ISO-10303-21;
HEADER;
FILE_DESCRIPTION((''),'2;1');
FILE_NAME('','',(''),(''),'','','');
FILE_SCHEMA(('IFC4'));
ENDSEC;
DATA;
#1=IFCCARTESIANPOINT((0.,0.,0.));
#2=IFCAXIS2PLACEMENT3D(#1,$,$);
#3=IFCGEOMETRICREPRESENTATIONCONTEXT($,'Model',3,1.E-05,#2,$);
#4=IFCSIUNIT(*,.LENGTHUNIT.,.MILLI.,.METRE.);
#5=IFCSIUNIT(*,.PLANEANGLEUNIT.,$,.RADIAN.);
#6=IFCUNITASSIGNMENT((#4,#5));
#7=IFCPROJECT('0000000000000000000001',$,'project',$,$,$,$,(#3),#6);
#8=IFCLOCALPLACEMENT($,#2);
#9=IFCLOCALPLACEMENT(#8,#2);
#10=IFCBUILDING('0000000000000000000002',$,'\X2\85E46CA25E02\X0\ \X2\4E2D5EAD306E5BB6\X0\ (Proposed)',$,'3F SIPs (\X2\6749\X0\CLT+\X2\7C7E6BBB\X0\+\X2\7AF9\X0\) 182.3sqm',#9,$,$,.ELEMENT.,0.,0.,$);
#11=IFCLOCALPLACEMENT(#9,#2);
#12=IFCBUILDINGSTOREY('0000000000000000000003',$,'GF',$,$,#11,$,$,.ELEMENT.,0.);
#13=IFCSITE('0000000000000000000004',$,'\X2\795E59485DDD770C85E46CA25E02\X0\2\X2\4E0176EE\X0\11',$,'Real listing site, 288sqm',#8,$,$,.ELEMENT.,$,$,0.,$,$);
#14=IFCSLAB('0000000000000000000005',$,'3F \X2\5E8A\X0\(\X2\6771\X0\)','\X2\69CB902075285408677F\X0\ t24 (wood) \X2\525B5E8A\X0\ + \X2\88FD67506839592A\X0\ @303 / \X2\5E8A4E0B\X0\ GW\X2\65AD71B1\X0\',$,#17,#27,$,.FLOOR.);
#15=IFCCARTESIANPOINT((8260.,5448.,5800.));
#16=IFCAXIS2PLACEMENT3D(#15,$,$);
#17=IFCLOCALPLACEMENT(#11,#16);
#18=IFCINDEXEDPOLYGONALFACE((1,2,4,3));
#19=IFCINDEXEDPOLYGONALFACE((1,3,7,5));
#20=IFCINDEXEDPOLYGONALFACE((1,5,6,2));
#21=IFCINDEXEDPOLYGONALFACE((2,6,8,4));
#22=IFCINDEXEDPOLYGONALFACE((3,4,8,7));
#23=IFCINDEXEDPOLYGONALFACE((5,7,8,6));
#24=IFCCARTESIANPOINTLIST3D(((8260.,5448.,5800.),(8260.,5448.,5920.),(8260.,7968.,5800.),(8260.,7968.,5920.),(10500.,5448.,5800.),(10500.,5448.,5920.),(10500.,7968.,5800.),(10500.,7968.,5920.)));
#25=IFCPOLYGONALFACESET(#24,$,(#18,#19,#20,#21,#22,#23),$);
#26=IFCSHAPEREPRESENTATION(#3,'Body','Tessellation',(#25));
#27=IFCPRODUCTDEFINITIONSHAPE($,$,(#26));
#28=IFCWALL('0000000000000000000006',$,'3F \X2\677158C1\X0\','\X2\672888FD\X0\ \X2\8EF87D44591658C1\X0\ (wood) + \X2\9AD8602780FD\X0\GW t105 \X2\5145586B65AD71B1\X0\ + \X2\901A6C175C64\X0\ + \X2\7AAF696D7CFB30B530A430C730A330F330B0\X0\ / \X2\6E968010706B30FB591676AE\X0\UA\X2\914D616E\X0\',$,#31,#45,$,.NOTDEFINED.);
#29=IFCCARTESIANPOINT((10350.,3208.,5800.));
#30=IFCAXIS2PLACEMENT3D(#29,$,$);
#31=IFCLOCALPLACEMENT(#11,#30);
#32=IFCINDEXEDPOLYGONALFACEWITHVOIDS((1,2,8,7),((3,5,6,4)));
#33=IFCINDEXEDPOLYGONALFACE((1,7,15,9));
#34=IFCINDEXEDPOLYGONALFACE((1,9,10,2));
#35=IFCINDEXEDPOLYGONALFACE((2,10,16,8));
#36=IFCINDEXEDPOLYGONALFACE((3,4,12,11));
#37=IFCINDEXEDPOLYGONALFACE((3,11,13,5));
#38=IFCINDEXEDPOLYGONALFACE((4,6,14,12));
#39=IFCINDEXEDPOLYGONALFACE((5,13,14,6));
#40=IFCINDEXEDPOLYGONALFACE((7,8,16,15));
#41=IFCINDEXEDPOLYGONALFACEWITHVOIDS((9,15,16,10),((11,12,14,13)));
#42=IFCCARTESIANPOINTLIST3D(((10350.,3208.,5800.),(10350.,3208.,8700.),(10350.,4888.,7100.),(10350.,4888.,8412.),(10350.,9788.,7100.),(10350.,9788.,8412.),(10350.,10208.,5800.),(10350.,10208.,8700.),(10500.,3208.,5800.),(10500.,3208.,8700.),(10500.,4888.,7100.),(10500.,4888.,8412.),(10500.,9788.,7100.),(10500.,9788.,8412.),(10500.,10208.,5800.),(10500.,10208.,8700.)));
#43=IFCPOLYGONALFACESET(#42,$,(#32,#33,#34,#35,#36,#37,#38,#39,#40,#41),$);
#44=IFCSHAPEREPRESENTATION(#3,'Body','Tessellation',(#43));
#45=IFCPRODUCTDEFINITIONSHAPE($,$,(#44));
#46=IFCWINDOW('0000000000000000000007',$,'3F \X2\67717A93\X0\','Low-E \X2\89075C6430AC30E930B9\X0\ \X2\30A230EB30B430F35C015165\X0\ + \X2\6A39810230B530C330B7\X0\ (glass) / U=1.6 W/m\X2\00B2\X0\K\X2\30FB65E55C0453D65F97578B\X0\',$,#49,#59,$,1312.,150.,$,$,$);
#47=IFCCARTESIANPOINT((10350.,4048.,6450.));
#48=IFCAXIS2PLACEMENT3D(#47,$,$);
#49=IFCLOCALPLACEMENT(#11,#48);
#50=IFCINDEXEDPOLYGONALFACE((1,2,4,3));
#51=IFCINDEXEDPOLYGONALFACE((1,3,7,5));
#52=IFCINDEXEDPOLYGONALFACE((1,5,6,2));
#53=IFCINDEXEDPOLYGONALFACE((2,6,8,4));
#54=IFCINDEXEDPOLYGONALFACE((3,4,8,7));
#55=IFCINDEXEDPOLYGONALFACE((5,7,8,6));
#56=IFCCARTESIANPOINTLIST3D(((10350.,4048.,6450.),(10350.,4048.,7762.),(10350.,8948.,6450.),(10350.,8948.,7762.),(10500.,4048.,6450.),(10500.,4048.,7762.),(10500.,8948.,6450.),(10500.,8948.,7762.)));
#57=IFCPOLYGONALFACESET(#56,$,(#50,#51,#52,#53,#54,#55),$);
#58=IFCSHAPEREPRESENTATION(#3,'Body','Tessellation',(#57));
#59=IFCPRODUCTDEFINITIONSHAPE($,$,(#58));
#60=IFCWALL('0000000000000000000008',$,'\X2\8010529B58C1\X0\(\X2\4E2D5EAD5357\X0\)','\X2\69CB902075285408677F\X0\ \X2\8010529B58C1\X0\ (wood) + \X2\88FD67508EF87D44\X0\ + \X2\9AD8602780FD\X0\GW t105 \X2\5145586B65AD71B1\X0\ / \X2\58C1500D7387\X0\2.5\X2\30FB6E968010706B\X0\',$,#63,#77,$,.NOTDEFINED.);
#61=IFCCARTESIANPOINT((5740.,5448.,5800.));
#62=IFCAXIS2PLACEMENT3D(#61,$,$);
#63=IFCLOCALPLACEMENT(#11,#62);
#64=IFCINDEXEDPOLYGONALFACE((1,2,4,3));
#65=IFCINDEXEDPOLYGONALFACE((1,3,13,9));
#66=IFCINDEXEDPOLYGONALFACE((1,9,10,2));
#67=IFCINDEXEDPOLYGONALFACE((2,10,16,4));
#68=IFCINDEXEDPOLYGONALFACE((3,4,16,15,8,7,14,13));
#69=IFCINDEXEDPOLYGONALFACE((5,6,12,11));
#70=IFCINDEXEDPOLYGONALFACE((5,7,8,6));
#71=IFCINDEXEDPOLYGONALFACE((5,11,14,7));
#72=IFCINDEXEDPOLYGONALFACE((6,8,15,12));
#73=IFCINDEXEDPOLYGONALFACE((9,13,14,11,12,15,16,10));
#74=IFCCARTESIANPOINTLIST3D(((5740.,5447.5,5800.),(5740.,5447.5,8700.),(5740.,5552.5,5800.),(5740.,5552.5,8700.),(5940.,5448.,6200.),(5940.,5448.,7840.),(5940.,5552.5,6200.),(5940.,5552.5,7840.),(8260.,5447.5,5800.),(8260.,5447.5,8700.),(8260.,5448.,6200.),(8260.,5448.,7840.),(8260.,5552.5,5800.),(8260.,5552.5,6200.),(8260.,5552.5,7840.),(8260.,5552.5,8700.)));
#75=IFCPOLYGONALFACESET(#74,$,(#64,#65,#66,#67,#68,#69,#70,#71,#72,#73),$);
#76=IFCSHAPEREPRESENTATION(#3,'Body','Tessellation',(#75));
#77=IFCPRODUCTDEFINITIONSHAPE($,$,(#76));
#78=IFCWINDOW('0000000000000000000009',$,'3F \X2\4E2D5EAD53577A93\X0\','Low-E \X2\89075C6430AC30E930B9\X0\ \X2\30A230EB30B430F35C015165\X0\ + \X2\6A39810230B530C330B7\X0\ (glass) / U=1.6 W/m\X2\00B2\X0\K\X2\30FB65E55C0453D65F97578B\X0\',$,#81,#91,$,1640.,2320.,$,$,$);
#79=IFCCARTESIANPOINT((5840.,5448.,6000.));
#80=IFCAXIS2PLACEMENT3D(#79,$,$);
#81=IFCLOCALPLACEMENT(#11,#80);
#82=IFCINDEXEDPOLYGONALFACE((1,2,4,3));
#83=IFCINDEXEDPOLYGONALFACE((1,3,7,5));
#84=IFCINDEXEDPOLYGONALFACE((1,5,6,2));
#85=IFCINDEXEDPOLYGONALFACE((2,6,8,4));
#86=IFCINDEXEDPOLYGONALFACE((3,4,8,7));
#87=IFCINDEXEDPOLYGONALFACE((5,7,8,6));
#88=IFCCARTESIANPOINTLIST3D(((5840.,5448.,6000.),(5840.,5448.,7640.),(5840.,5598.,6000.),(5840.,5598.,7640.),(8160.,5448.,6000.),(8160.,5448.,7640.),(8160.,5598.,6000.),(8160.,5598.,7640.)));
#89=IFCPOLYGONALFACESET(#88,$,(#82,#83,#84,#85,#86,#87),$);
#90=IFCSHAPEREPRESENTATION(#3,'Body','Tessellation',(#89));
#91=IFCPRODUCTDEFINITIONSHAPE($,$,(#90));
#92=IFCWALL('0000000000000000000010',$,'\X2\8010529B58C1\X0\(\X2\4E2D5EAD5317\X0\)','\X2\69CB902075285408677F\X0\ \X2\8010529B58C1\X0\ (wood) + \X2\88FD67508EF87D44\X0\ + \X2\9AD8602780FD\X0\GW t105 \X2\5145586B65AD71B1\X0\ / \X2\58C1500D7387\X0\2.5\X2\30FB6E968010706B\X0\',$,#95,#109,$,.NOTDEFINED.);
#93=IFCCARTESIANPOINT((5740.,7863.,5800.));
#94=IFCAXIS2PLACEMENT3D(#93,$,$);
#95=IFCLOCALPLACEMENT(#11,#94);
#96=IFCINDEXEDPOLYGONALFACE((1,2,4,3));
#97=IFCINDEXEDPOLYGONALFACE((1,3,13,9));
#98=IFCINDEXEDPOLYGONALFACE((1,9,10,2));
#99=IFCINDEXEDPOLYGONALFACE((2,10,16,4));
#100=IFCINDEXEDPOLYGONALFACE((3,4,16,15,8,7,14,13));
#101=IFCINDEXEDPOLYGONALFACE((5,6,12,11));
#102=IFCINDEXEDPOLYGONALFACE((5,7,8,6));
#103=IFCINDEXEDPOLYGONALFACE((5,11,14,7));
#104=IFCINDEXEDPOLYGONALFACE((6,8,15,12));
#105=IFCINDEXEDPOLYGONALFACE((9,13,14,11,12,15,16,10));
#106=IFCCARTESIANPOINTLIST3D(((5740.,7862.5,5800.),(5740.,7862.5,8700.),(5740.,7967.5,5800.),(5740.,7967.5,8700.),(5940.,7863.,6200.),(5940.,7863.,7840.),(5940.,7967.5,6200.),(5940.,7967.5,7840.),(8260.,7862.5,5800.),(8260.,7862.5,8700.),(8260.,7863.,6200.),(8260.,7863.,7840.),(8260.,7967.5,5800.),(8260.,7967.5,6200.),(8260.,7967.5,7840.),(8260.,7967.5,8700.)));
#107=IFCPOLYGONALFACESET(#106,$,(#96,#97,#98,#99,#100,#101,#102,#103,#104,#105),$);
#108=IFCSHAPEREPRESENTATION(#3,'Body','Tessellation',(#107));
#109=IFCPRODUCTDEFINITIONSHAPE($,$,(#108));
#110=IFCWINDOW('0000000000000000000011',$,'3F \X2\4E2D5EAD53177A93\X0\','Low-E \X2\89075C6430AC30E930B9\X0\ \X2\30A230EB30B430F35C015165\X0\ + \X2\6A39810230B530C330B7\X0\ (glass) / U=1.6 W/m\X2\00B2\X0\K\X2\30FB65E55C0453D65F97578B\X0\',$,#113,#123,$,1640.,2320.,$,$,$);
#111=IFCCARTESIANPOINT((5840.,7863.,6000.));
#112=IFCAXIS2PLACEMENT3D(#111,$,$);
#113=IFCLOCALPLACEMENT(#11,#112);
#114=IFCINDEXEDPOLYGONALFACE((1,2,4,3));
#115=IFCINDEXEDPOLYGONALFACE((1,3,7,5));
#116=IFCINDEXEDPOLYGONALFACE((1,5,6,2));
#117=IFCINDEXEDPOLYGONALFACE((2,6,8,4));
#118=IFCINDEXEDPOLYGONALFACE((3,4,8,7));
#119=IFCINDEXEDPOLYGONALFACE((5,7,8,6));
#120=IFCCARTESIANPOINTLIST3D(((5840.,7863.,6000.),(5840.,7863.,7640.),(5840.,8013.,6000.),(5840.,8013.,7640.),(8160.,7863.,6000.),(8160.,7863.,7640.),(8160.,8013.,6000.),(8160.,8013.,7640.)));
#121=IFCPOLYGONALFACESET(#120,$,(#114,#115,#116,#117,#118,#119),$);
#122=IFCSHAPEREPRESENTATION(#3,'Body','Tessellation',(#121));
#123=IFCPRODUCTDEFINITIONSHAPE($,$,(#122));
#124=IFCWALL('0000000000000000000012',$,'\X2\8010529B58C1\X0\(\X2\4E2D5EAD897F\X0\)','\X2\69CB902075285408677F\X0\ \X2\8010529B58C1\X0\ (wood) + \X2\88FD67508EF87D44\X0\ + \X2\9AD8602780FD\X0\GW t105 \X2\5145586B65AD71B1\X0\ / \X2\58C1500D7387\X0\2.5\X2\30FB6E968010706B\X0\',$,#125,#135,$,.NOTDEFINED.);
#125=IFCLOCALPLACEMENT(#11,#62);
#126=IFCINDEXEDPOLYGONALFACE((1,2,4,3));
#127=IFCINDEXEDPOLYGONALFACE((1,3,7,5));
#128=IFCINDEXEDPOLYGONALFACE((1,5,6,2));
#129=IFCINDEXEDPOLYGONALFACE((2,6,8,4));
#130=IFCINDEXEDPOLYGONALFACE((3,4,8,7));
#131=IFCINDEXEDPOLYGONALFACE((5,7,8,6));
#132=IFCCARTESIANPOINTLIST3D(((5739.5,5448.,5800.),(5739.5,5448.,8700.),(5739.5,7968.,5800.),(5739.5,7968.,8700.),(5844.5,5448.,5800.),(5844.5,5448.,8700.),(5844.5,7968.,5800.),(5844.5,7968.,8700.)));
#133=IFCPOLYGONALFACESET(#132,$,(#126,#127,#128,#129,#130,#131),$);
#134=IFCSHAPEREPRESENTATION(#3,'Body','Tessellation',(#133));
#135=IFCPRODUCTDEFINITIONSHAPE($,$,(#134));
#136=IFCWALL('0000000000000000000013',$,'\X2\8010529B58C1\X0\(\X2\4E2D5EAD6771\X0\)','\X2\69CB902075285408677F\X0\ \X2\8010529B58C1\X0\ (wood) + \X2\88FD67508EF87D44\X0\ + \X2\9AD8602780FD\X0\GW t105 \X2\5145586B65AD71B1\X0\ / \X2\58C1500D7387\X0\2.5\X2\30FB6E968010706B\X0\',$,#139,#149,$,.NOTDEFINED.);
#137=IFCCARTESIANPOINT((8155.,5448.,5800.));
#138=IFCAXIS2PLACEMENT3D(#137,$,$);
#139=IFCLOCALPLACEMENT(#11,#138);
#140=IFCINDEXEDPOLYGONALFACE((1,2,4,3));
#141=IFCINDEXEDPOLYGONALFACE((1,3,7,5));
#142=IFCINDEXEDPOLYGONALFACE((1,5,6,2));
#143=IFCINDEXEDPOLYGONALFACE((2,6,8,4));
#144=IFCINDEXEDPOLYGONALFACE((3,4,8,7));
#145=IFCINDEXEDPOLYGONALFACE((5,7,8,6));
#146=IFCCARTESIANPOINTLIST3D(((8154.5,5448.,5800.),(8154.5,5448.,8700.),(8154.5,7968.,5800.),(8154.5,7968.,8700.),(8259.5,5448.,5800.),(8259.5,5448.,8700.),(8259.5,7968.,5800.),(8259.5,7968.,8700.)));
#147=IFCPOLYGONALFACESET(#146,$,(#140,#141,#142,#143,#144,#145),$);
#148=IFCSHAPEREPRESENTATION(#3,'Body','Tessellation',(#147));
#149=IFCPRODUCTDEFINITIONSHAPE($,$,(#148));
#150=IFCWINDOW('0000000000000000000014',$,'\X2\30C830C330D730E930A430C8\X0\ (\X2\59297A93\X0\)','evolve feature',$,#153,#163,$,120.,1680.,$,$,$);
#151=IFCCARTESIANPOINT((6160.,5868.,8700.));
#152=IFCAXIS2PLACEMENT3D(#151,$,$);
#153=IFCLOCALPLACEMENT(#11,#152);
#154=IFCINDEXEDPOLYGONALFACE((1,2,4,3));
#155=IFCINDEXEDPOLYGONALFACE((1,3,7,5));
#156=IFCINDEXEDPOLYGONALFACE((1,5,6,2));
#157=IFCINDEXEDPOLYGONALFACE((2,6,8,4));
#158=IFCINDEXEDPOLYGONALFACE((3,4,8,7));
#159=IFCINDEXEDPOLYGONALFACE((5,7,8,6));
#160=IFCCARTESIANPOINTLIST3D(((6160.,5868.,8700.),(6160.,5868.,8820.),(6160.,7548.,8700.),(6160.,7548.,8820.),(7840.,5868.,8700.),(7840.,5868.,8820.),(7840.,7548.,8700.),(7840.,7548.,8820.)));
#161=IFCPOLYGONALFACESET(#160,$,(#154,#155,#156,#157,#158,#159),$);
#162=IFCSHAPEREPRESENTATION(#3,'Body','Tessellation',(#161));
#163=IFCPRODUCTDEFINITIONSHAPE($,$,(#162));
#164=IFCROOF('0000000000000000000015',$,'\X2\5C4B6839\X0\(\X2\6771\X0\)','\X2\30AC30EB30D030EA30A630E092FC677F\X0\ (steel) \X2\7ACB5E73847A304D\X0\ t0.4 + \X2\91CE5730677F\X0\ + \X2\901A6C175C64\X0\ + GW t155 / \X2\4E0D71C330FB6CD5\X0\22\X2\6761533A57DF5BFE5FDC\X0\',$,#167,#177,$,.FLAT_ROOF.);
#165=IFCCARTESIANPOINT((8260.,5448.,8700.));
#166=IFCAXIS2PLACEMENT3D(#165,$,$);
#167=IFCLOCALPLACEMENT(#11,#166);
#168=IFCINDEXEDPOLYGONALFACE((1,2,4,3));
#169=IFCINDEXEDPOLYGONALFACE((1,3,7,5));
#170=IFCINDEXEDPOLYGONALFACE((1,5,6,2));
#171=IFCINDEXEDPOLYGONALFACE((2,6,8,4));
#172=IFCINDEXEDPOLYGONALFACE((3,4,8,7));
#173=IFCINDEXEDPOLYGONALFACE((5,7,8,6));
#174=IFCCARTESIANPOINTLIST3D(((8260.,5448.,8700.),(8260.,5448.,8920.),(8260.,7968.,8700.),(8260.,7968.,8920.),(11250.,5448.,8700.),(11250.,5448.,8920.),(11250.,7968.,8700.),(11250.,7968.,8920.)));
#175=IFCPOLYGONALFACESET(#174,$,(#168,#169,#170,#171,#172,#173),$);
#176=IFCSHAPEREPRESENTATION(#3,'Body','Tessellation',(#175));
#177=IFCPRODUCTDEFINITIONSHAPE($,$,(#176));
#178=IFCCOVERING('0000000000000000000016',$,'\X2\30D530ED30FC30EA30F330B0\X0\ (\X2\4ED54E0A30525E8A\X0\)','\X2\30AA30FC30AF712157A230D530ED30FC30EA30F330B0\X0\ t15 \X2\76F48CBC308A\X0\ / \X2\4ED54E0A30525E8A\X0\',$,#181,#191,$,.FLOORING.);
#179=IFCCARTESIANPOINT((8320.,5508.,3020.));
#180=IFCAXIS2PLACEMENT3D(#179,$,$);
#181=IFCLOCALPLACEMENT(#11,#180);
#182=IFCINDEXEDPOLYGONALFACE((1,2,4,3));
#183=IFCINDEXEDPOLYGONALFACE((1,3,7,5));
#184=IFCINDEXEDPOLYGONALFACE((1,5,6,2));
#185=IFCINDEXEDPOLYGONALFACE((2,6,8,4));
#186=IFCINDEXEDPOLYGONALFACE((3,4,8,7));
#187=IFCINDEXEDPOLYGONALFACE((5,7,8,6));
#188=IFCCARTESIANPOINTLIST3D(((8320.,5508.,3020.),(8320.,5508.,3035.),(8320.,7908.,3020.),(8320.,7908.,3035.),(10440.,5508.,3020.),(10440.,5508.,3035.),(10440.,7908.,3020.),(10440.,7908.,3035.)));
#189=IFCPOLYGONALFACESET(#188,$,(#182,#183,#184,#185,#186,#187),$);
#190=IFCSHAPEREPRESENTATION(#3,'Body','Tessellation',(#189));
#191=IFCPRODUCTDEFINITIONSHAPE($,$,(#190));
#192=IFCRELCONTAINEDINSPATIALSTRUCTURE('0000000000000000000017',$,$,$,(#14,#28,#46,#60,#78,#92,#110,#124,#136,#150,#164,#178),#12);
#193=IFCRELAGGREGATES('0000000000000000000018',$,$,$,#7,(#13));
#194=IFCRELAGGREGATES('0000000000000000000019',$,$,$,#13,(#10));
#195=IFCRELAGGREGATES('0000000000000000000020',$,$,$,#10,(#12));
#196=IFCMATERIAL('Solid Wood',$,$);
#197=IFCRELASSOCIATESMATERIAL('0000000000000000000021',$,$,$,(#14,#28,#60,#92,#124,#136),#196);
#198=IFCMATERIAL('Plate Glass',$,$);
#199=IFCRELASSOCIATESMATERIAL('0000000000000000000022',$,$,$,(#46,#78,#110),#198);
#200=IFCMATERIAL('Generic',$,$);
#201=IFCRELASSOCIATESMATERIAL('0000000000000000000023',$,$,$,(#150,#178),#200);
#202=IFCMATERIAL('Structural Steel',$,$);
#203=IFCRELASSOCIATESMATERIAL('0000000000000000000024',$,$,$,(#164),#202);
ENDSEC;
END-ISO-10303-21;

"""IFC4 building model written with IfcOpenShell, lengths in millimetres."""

from ifc_helpers import new_model, si_unit, frame, frame_2d, origin, place, context, project, spatial, rectangle, extrude, material, element, fill, save


model = new_model("IFC4")

# Units and contexts
model_context = context("Model", 3, precision=1e-05, world=origin())
ifc_project = project(units=[si_unit("LENGTHUNIT", "METRE", prefix="MILLI"), si_unit("PLANEANGLEUNIT", "RADIAN")], contexts=[model_context])

# Site, building, storey
site_placement = place(None, origin())
site = spatial("IfcSite", under=ifc_project, at=site_placement, Name="神奈川県藤沢市2丁目11", ObjectType="Real listing site, 288sqm", CompositionType="ELEMENT", RefElevation=0.0)
building_placement = place(site_placement, origin())
building = spatial("IfcBuilding", under=site, at=building_placement, Name="藤沢市 中庭の家 (Proposed)", ObjectType="3F SIPs (杉CLT+籾殻+竹) 182.3sqm", CompositionType="ELEMENT", ElevationOfRefHeight=0.0, ElevationOfTerrain=0.0)
storey_placement = place(building_placement, origin())
storey = spatial("IfcBuildingStorey", under=building, at=storey_placement, Name="GF", CompositionType="ELEMENT", Elevation=0.0)

# Slab
ifc_material_1 = material(Name="Solid Wood")
slab_placement = place(storey_placement, frame((8260.0, 5448.0, 5800.0)))
element("IfcSlab", 1, at=slab_placement, inside=storey, material=ifc_material_1, Name="3F 床(東)", Description="構造用合板 t24 (wood) 剛床 + 製材根太 @303 / 床下 GW断熱", PredefinedType="FLOOR", context=model_context, shape_type="SweptSolid", body=[
    extrude(rectangle(XDim=2240.0, YDim=2520.0, at=frame_2d((1120.0, 1260.0))), frame((8260.0, 5448.0, 5800.0)), (0.0, 0.0, 1.0), 120.0),
])

# Walls, openings, windows
wall_1_placement = place(storey_placement, frame((10350.0, 3208.0, 5800.0)))
wall_1 = element("IfcWall", 2, at=wall_1_placement, inside=storey, material=ifc_material_1, Name="3F 東壁", Description="木製 軸組外壁 (wood) + 高性能GW t105 充填断熱 + 通気層 + 窯業系サイディング / 準耐火・外皮UA配慮", PredefinedType="NOTDEFINED", context=model_context, shape_type="SweptSolid", body=[
    extrude(rectangle(XDim=150.0, YDim=7000.0, at=frame_2d((75.0, 3500.0))), frame((10350.0, 3208.0, 5800.0)), (0.0, 0.0, 1.0), 2900.0),
])
opening_1_placement = place(storey_placement, frame((10350.0, 4048.0, 6450.0)))
opening_1 = element("IfcOpeningElement", 3, at=opening_1_placement, cuts=wall_1, PredefinedType="NOTDEFINED", context=model_context, shape_type="SweptSolid", body=[
    extrude(rectangle(XDim=150.0, YDim=4900.0, at=frame_2d((75.0, 2450.0))), frame((10350.0, 4048.0, 6450.0)), (0.0, 0.0, 1.0), 1312.0),
])
ifc_material_2 = material(Name="Plate Glass")
window_1_placement = place(storey_placement, frame((10350.0, 4048.0, 6450.0)))
window_1 = element("IfcWindow", 4, at=window_1_placement, inside=storey, material=ifc_material_2, Name="3F 東窓", Description="Low-E 複層ガラス アルゴン封入 + 樹脂サッシ (glass) / U=1.6 W/m²K・日射取得型", OverallHeight=1312.0, OverallWidth=150.0, context=model_context, shape_type="SweptSolid", body=[
    extrude(rectangle(XDim=150.0, YDim=4900.0, at=frame_2d((75.0, 2450.0))), frame((10350.0, 4048.0, 6450.0)), (0.0, 0.0, 1.0), 1312.0),
])
fill(opening_1, window_1)
wall_2_placement = place(storey_placement, frame((5740.0, 5448.0, 5800.0)))
wall_2 = element("IfcWall", 5, at=wall_2_placement, inside=storey, material=ifc_material_1, Name="耐力壁(中庭南)", Description="構造用合板 耐力壁 (wood) + 製材軸組 + 高性能GW t105 充填断熱 / 壁倍率2.5・準耐火", PredefinedType="NOTDEFINED", context=model_context, shape_type="SweptSolid", body=[
    extrude(rectangle(XDim=2520.0, YDim=105.0, at=frame_2d((1260.0, 52.0))), frame((5740.0, 5448.0, 5800.0)), (0.0, 0.0, 1.0), 2900.0),
])
opening_2_placement = place(storey_placement, frame((5840.0, 5448.0, 6000.0)))
opening_2 = element("IfcOpeningElement", 6, at=opening_2_placement, cuts=wall_2, PredefinedType="NOTDEFINED", context=model_context, shape_type="SweptSolid", body=[
    extrude(rectangle(XDim=2320.0, YDim=150.0, at=frame_2d((1160.0, 75.0))), frame((5840.0, 5448.0, 6000.0)), (0.0, 0.0, 1.0), 1640.0),
])
window_2_placement = place(storey_placement, frame((5840.0, 5448.0, 6000.0)))
window_2 = element("IfcWindow", 7, at=window_2_placement, inside=storey, material=ifc_material_2, Name="3F 中庭南窓", Description="Low-E 複層ガラス アルゴン封入 + 樹脂サッシ (glass) / U=1.6 W/m²K・日射取得型", OverallHeight=1640.0, OverallWidth=2320.0, context=model_context, shape_type="SweptSolid", body=[
    extrude(rectangle(XDim=2320.0, YDim=150.0, at=frame_2d((1160.0, 75.0))), frame((5840.0, 5448.0, 6000.0)), (0.0, 0.0, 1.0), 1640.0),
])
fill(opening_2, window_2)
wall_3_placement = place(storey_placement, frame((5740.0, 7863.0, 5800.0)))
wall_3 = element("IfcWall", 8, at=wall_3_placement, inside=storey, material=ifc_material_1, Name="耐力壁(中庭北)", Description="構造用合板 耐力壁 (wood) + 製材軸組 + 高性能GW t105 充填断熱 / 壁倍率2.5・準耐火", PredefinedType="NOTDEFINED", context=model_context, shape_type="SweptSolid", body=[
    extrude(rectangle(XDim=2520.0, YDim=105.0, at=frame_2d((1260.0, 52.0))), frame((5740.0, 7863.0, 5800.0)), (0.0, 0.0, 1.0), 2900.0),
])
opening_3_placement = place(storey_placement, frame((5840.0, 7863.0, 6000.0)))
opening_3 = element("IfcOpeningElement", 9, at=opening_3_placement, cuts=wall_3, PredefinedType="NOTDEFINED", context=model_context, shape_type="SweptSolid", body=[
    extrude(rectangle(XDim=2320.0, YDim=150.0, at=frame_2d((1160.0, 75.0))), frame((5840.0, 7863.0, 6000.0)), (0.0, 0.0, 1.0), 1640.0),
])
window_3_placement = place(storey_placement, frame((5840.0, 7863.0, 6000.0)))
window_3 = element("IfcWindow", 10, at=window_3_placement, inside=storey, material=ifc_material_2, Name="3F 中庭北窓", Description="Low-E 複層ガラス アルゴン封入 + 樹脂サッシ (glass) / U=1.6 W/m²K・日射取得型", OverallHeight=1640.0, OverallWidth=2320.0, context=model_context, shape_type="SweptSolid", body=[
    extrude(rectangle(XDim=2320.0, YDim=150.0, at=frame_2d((1160.0, 75.0))), frame((5840.0, 7863.0, 6000.0)), (0.0, 0.0, 1.0), 1640.0),
])
fill(opening_3, window_3)

# Walls
wall_4_placement = place(storey_placement, frame((5740.0, 5448.0, 5800.0)))
element("IfcWall", 11, at=wall_4_placement, inside=storey, material=ifc_material_1, Name="耐力壁(中庭西)", Description="構造用合板 耐力壁 (wood) + 製材軸組 + 高性能GW t105 充填断熱 / 壁倍率2.5・準耐火", PredefinedType="NOTDEFINED", context=model_context, shape_type="SweptSolid", body=[
    extrude(rectangle(XDim=105.0, YDim=2520.0, at=frame_2d((52.0, 1260.0))), frame((5740.0, 5448.0, 5800.0)), (0.0, 0.0, 1.0), 2900.0),
])
wall_5_placement = place(storey_placement, frame((8155.0, 5448.0, 5800.0)))
element("IfcWall", 12, at=wall_5_placement, inside=storey, material=ifc_material_1, Name="耐力壁(中庭東)", Description="構造用合板 耐力壁 (wood) + 製材軸組 + 高性能GW t105 充填断熱 / 壁倍率2.5・準耐火", PredefinedType="NOTDEFINED", context=model_context, shape_type="SweptSolid", body=[
    extrude(rectangle(XDim=105.0, YDim=2520.0, at=frame_2d((52.0, 1260.0))), frame((8155.0, 5448.0, 5800.0)), (0.0, 0.0, 1.0), 2900.0),
])

# Window
ifc_material_3 = material(Name="Generic")
window_4_placement = place(storey_placement, frame((6160.0, 5868.0, 8700.0)))
element("IfcWindow", 13, at=window_4_placement, inside=storey, material=ifc_material_3, Name="トップライト (天窓)", Description="evolve feature", OverallHeight=120.0, OverallWidth=1680.0, context=model_context, shape_type="SweptSolid", body=[
    extrude(rectangle(XDim=1680.0, YDim=1680.0, at=frame_2d((840.0, 840.0))), frame((6160.0, 5868.0, 8700.0)), (0.0, 0.0, 1.0), 120.0),
])

# Roof
ifc_material_4 = material(Name="Structural Steel")
for number, where, name in (
    (14, (8260.0, 5448.0, 8700.0), "屋根(東)"),
):
    element("IfcRoof", number, at=place(storey_placement, frame(where)), inside=storey, material=ifc_material_4, Name=name, Description="ガルバリウム鋼板 (steel) 立平葺き t0.4 + 野地板 + 通気層 + GW t155 / 不燃・法22条区域対応", PredefinedType="FLAT_ROOF", context=model_context, shape_type="SweptSolid", body=[
        extrude(rectangle(XDim=2990.0, YDim=2520.0, at=frame_2d((1495.0, 1260.0))), frame((8260.0, 5448.0, 8700.0)), (0.0, 0.0, 1.0), 220.0),
    ])

# Covering
covering_1_placement = place(storey_placement, frame((8320.0, 5508.0, 3020.0)))
element("IfcCovering", 15, at=covering_1_placement, inside=storey, material=ifc_material_3, Name="フローリング (仕上げ床)", Description="オーク無垢フローリング t15 直貼り / 仕上げ床", PredefinedType="FLOORING", context=model_context, shape_type="SweptSolid", body=[
    extrude(rectangle(XDim=2120.0, YDim=2400.0, at=frame_2d((1060.0, 1200.0))), frame((8320.0, 5508.0, 3020.0)), (0.0, 0.0, 1.0), 15.0),
])

save(model, "model.ifc")
